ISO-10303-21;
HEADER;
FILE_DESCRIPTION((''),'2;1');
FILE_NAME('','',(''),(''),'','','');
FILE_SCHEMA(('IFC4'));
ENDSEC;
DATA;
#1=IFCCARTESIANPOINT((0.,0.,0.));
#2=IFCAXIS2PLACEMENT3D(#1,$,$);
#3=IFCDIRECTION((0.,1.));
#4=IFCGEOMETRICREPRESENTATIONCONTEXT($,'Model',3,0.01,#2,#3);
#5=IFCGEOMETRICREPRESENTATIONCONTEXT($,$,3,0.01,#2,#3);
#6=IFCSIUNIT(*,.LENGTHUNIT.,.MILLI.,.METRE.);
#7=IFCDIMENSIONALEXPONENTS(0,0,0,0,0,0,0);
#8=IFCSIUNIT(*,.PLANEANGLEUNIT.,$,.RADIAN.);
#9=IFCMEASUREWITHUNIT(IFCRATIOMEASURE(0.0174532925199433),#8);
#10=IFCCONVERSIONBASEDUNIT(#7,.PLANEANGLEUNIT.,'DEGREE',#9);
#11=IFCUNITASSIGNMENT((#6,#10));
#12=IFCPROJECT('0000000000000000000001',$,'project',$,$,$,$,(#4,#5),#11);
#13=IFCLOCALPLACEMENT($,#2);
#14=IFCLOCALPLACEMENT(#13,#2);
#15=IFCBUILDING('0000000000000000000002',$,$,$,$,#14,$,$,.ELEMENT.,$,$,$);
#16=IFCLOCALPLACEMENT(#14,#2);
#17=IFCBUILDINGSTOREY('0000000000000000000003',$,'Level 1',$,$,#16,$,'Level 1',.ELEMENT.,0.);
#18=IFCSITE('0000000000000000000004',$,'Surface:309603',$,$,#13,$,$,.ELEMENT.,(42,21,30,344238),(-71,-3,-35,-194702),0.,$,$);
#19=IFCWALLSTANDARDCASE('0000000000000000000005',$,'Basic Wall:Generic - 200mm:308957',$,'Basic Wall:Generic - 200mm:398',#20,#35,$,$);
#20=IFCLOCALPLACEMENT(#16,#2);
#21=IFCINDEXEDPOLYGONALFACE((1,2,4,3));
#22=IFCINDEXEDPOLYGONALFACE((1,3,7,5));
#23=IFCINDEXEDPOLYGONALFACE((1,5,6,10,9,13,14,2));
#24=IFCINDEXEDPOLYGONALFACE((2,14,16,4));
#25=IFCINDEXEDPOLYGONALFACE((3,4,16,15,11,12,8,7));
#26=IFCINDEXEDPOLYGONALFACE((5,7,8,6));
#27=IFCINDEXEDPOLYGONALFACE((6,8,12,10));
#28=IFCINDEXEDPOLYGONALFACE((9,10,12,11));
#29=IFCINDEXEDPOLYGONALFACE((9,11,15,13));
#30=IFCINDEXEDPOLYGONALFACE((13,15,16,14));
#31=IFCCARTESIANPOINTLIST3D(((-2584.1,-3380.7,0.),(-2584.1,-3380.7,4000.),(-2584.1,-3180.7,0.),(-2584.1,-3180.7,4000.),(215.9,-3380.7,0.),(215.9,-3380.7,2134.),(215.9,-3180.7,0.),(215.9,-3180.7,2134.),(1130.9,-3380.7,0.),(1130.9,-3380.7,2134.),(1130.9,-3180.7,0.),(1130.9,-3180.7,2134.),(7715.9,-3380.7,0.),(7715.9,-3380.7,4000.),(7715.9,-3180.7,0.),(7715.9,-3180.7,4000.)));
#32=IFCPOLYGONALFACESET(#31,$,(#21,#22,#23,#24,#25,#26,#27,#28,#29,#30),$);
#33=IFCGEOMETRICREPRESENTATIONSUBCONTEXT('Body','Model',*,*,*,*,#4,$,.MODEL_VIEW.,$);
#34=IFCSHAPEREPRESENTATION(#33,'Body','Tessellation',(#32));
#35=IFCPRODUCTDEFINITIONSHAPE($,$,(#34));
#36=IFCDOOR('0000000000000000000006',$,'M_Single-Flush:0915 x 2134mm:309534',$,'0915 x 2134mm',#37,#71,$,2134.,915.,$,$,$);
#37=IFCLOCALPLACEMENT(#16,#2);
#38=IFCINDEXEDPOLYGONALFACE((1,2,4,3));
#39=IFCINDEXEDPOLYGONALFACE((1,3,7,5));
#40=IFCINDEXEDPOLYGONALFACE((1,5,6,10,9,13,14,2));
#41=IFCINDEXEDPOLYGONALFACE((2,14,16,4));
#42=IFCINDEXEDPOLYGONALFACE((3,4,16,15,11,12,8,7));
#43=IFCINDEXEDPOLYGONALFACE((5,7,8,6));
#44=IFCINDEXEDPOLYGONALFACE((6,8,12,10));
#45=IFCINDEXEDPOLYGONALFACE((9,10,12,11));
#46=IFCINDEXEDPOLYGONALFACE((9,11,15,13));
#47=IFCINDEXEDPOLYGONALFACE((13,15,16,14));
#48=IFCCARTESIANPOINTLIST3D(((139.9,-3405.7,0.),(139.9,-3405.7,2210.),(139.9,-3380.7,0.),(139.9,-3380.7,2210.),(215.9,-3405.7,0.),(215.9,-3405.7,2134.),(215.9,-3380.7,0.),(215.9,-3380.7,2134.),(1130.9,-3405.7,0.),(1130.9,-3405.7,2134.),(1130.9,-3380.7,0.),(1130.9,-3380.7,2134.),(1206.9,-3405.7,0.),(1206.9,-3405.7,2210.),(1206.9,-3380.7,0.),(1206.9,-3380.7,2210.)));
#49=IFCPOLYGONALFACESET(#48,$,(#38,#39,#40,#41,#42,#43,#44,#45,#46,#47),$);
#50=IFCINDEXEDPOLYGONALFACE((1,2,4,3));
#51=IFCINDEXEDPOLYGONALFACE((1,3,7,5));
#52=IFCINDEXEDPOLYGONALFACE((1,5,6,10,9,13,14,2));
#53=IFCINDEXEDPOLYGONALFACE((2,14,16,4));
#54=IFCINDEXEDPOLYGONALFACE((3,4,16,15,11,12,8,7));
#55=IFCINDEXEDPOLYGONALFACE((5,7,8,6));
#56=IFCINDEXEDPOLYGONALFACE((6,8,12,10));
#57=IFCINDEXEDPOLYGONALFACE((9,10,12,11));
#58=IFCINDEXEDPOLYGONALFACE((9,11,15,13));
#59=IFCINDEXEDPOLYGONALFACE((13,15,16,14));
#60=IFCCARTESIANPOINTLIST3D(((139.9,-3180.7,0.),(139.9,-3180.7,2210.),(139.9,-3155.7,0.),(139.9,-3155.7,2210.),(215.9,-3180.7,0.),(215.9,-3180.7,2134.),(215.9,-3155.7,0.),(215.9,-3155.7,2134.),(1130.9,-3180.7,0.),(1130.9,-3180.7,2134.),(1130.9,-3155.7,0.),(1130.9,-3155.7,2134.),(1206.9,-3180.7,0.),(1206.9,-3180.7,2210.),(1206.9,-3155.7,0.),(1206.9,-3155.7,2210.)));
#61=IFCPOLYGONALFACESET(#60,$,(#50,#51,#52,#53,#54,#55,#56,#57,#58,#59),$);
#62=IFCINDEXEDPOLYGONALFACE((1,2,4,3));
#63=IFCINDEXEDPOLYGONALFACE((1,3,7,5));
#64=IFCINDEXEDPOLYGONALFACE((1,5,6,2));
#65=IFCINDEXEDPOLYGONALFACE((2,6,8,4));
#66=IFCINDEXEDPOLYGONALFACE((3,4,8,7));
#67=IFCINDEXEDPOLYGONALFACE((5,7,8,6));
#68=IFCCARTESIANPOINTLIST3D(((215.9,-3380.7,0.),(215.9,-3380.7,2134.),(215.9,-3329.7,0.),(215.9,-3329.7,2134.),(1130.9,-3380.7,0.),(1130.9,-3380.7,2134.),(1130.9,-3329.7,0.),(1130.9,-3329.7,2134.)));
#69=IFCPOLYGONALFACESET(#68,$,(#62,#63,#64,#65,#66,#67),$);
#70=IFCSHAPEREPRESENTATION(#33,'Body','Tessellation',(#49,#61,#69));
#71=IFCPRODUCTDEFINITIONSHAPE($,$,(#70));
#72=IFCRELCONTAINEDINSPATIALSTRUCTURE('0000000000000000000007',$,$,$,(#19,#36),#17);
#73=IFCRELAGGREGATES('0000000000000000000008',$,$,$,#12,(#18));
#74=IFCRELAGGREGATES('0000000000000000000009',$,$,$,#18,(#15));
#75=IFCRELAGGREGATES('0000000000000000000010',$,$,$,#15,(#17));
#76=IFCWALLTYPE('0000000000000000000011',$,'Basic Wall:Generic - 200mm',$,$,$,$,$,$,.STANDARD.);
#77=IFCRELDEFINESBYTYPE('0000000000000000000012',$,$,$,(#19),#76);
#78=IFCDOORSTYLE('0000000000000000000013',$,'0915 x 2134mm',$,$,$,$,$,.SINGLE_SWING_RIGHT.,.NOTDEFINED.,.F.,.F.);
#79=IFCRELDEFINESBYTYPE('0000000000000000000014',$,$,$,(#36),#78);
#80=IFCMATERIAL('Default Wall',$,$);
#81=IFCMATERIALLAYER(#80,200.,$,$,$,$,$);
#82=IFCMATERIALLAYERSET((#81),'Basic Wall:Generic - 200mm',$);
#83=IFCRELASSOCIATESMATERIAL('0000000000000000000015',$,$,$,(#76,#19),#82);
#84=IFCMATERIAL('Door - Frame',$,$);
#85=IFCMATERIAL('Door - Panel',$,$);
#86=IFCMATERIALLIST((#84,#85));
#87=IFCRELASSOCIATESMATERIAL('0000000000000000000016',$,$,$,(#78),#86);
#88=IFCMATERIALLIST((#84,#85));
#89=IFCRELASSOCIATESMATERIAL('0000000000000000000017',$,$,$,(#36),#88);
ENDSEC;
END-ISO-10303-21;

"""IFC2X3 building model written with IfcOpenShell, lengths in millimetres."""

from ifc_helpers import new_model, entity, si_unit, converted_unit, direction, frame, frame_2d, origin, place, context, subcontext, project, spatial, polyline, rectangle, outline, extrude, source, transform, mapped, material, material_list, layer, layer_set, layer_usage, type_object, type_shapes, element, fill, save


model = new_model("IFC2X3")

# Units and contexts
model_context = context("Model", 3, precision=0.01, world=origin(), true_north=direction((0.0, 1.0)))
context_of_model = context(None, 3, precision=0.01, world=origin(), true_north=direction((0.0, 1.0)))
body_context = subcontext(model_context, "Body", "Model", "MODEL_VIEW")
ifc_project = project(units=[si_unit("LENGTHUNIT", "METRE", prefix="MILLI"), converted_unit("PLANEANGLEUNIT", "DEGREE", entity("IfcRatioMeasure", 0.0174532925199433), si_unit("PLANEANGLEUNIT", "RADIAN"), dimensions=[0, 0, 0, 0, 0, 0, 0])], contexts=[model_context, context_of_model])

# Site, building, storey
site_placement = place(None, origin())
site = spatial("IfcSite", under=ifc_project, at=site_placement, Name="Surface:309603", CompositionType="ELEMENT", RefLatitude=(42, 21, 30, 344238), RefLongitude=(-71, -3, -35, -194702), RefElevation=0.0)
building_placement = place(site_placement, origin())
building = spatial("IfcBuilding", under=site, at=building_placement, CompositionType="ELEMENT")
storey_placement = place(building_placement, origin())
storey = spatial("IfcBuildingStorey", under=building, at=storey_placement, Name="Level 1", LongName="Level 1", CompositionType="ELEMENT", Elevation=0.0)

# Shared definitions
ifc_material_1 = material(Name="Default Wall")
ifc_layer_1 = layer(ifc_material_1, 200.0)
ifc_layer_set_1 = layer_set([ifc_layer_1], Name="Basic Wall:Generic - 200mm")
wall_type = type_object("IfcWallType", Name="Basic Wall:Generic - 200mm", PredefinedType="STANDARD", material=ifc_layer_set_1)

# Shared definitions
ifc_material_2 = material(Name="Door - Frame")
ifc_material_3 = material(Name="Door - Panel")
ifc_material_list_1 = material_list([ifc_material_2, ifc_material_3])
door_style = type_object("IfcDoorStyle", Name="0915 x 2134mm", ConstructionType="NOTDEFINED", OperationType="SINGLE_SWING_RIGHT", ParameterTakesPrecedence=False, Sizeable=False, material=ifc_material_list_1)
shared_shape_1 = source(origin(), body_context, "Body", "SweptSolid", [
    extrude(outline(polyline([(-533.5, -1124.0), (533.5, -1124.0), (533.5, 1086.0), (457.5, 1086.0), (457.5, -1048.0), (-457.5, -1048.0), (-457.5, 1086.0), (-533.5, 1086.0), (-533.5, -1124.0)])), frame((457.5, 200.0, 1086.0), z_axis=(0.0, 1.0, 0.0), x_axis=(1.0, 0.0, 0.0)), (0.0, 0.0, 1.0), 25.0),
    extrude(outline(polyline([(-1124.0, -533.5), (1086.0, -533.5), (1086.0, -457.5), (-1048.0, -457.5), (-1048.0, 457.5), (1086.0, 457.5), (1086.0, 533.5), (-1124.0, 533.5), (-1124.0, -533.5)])), frame((457.5, -25.0, 1086.0), z_axis=(0.0, 1.0, 0.0), x_axis=(0.0, 0.0, -1.0)), (0.0, 0.0, 1.0), 25.0),
    extrude(rectangle(XDim=51.0, YDim=915.0, at=frame_2d((0.0, 0.0), x_axis=(1.0, 0.0))), frame((457.5, 174.5, 0.0), z_axis=(0.0, 0.0, 1.0), x_axis=(0.0, 1.0, 0.0)), (0.0, 0.0, 1.0), 2134.0),
])
type_shapes(door_style, [shared_shape_1])

# Wall, opening, door
ifc_layer_usage_1 = layer_usage(ifc_layer_set_1, "AXIS2", "NEGATIVE", 100.0)
wall_1_placement = place(storey_placement, frame((-2584.1, -3280.7, 0.0)))
wall_1 = element("IfcWallStandardCase", 1, at=wall_1_placement, inside=storey, type_object=wall_type, material=ifc_layer_usage_1, Name="Basic Wall:Generic - 200mm:308957", ObjectType="Basic Wall:Generic - 200mm:398", context=body_context, shape_type="SweptSolid", body=[
    extrude(rectangle(XDim=10300.0, YDim=200.0, at=frame_2d((5150.0, 0.0), x_axis=(-1.0, 0.0))), origin(), (0.0, 0.0, 1.0), 4000.0),
])
opening_1_placement = place(wall_1_placement, frame((3715.0, 100.0, 0.0)))
opening_1 = element("IfcOpeningElement", 2, at=opening_1_placement, cuts=wall_1, ObjectType="Opening", context=body_context, shape_type="SweptSolid", body=[
    extrude(rectangle(XDim=915.0, YDim=2134.0, at=frame_2d((1067.0, 457.5), x_axis=(0.0, 1.0))), frame((0.0, 0.0, 0.0), z_axis=(0.0, -1.0, 0.0), x_axis=(0.0, 0.0, 1.0)), (0.0, 0.0, 1.0), 200.0),
])
ifc_material_list_2 = material_list([ifc_material_2, ifc_material_3])
door_1_placement = place(opening_1_placement, frame((0.0, 0.0, 0.0), z_axis=(0.0, 0.0, 1.0), x_axis=(-1.0, 0.0, 0.0)))
door_1 = element("IfcDoor", 3, at=door_1_placement, inside=storey, type_object=door_style, material=ifc_material_list_2, Name="M_Single-Flush:0915 x 2134mm:309534", ObjectType="0915 x 2134mm", OverallHeight=2134.0, OverallWidth=915.0, context=body_context, shape_type="MappedRepresentation", body=[
    mapped(shared_shape_1, transform((0.0, 0.0, 0.0), scale=1.0)),
])
fill(opening_1, door_1)

save(model, "model.ifc")
